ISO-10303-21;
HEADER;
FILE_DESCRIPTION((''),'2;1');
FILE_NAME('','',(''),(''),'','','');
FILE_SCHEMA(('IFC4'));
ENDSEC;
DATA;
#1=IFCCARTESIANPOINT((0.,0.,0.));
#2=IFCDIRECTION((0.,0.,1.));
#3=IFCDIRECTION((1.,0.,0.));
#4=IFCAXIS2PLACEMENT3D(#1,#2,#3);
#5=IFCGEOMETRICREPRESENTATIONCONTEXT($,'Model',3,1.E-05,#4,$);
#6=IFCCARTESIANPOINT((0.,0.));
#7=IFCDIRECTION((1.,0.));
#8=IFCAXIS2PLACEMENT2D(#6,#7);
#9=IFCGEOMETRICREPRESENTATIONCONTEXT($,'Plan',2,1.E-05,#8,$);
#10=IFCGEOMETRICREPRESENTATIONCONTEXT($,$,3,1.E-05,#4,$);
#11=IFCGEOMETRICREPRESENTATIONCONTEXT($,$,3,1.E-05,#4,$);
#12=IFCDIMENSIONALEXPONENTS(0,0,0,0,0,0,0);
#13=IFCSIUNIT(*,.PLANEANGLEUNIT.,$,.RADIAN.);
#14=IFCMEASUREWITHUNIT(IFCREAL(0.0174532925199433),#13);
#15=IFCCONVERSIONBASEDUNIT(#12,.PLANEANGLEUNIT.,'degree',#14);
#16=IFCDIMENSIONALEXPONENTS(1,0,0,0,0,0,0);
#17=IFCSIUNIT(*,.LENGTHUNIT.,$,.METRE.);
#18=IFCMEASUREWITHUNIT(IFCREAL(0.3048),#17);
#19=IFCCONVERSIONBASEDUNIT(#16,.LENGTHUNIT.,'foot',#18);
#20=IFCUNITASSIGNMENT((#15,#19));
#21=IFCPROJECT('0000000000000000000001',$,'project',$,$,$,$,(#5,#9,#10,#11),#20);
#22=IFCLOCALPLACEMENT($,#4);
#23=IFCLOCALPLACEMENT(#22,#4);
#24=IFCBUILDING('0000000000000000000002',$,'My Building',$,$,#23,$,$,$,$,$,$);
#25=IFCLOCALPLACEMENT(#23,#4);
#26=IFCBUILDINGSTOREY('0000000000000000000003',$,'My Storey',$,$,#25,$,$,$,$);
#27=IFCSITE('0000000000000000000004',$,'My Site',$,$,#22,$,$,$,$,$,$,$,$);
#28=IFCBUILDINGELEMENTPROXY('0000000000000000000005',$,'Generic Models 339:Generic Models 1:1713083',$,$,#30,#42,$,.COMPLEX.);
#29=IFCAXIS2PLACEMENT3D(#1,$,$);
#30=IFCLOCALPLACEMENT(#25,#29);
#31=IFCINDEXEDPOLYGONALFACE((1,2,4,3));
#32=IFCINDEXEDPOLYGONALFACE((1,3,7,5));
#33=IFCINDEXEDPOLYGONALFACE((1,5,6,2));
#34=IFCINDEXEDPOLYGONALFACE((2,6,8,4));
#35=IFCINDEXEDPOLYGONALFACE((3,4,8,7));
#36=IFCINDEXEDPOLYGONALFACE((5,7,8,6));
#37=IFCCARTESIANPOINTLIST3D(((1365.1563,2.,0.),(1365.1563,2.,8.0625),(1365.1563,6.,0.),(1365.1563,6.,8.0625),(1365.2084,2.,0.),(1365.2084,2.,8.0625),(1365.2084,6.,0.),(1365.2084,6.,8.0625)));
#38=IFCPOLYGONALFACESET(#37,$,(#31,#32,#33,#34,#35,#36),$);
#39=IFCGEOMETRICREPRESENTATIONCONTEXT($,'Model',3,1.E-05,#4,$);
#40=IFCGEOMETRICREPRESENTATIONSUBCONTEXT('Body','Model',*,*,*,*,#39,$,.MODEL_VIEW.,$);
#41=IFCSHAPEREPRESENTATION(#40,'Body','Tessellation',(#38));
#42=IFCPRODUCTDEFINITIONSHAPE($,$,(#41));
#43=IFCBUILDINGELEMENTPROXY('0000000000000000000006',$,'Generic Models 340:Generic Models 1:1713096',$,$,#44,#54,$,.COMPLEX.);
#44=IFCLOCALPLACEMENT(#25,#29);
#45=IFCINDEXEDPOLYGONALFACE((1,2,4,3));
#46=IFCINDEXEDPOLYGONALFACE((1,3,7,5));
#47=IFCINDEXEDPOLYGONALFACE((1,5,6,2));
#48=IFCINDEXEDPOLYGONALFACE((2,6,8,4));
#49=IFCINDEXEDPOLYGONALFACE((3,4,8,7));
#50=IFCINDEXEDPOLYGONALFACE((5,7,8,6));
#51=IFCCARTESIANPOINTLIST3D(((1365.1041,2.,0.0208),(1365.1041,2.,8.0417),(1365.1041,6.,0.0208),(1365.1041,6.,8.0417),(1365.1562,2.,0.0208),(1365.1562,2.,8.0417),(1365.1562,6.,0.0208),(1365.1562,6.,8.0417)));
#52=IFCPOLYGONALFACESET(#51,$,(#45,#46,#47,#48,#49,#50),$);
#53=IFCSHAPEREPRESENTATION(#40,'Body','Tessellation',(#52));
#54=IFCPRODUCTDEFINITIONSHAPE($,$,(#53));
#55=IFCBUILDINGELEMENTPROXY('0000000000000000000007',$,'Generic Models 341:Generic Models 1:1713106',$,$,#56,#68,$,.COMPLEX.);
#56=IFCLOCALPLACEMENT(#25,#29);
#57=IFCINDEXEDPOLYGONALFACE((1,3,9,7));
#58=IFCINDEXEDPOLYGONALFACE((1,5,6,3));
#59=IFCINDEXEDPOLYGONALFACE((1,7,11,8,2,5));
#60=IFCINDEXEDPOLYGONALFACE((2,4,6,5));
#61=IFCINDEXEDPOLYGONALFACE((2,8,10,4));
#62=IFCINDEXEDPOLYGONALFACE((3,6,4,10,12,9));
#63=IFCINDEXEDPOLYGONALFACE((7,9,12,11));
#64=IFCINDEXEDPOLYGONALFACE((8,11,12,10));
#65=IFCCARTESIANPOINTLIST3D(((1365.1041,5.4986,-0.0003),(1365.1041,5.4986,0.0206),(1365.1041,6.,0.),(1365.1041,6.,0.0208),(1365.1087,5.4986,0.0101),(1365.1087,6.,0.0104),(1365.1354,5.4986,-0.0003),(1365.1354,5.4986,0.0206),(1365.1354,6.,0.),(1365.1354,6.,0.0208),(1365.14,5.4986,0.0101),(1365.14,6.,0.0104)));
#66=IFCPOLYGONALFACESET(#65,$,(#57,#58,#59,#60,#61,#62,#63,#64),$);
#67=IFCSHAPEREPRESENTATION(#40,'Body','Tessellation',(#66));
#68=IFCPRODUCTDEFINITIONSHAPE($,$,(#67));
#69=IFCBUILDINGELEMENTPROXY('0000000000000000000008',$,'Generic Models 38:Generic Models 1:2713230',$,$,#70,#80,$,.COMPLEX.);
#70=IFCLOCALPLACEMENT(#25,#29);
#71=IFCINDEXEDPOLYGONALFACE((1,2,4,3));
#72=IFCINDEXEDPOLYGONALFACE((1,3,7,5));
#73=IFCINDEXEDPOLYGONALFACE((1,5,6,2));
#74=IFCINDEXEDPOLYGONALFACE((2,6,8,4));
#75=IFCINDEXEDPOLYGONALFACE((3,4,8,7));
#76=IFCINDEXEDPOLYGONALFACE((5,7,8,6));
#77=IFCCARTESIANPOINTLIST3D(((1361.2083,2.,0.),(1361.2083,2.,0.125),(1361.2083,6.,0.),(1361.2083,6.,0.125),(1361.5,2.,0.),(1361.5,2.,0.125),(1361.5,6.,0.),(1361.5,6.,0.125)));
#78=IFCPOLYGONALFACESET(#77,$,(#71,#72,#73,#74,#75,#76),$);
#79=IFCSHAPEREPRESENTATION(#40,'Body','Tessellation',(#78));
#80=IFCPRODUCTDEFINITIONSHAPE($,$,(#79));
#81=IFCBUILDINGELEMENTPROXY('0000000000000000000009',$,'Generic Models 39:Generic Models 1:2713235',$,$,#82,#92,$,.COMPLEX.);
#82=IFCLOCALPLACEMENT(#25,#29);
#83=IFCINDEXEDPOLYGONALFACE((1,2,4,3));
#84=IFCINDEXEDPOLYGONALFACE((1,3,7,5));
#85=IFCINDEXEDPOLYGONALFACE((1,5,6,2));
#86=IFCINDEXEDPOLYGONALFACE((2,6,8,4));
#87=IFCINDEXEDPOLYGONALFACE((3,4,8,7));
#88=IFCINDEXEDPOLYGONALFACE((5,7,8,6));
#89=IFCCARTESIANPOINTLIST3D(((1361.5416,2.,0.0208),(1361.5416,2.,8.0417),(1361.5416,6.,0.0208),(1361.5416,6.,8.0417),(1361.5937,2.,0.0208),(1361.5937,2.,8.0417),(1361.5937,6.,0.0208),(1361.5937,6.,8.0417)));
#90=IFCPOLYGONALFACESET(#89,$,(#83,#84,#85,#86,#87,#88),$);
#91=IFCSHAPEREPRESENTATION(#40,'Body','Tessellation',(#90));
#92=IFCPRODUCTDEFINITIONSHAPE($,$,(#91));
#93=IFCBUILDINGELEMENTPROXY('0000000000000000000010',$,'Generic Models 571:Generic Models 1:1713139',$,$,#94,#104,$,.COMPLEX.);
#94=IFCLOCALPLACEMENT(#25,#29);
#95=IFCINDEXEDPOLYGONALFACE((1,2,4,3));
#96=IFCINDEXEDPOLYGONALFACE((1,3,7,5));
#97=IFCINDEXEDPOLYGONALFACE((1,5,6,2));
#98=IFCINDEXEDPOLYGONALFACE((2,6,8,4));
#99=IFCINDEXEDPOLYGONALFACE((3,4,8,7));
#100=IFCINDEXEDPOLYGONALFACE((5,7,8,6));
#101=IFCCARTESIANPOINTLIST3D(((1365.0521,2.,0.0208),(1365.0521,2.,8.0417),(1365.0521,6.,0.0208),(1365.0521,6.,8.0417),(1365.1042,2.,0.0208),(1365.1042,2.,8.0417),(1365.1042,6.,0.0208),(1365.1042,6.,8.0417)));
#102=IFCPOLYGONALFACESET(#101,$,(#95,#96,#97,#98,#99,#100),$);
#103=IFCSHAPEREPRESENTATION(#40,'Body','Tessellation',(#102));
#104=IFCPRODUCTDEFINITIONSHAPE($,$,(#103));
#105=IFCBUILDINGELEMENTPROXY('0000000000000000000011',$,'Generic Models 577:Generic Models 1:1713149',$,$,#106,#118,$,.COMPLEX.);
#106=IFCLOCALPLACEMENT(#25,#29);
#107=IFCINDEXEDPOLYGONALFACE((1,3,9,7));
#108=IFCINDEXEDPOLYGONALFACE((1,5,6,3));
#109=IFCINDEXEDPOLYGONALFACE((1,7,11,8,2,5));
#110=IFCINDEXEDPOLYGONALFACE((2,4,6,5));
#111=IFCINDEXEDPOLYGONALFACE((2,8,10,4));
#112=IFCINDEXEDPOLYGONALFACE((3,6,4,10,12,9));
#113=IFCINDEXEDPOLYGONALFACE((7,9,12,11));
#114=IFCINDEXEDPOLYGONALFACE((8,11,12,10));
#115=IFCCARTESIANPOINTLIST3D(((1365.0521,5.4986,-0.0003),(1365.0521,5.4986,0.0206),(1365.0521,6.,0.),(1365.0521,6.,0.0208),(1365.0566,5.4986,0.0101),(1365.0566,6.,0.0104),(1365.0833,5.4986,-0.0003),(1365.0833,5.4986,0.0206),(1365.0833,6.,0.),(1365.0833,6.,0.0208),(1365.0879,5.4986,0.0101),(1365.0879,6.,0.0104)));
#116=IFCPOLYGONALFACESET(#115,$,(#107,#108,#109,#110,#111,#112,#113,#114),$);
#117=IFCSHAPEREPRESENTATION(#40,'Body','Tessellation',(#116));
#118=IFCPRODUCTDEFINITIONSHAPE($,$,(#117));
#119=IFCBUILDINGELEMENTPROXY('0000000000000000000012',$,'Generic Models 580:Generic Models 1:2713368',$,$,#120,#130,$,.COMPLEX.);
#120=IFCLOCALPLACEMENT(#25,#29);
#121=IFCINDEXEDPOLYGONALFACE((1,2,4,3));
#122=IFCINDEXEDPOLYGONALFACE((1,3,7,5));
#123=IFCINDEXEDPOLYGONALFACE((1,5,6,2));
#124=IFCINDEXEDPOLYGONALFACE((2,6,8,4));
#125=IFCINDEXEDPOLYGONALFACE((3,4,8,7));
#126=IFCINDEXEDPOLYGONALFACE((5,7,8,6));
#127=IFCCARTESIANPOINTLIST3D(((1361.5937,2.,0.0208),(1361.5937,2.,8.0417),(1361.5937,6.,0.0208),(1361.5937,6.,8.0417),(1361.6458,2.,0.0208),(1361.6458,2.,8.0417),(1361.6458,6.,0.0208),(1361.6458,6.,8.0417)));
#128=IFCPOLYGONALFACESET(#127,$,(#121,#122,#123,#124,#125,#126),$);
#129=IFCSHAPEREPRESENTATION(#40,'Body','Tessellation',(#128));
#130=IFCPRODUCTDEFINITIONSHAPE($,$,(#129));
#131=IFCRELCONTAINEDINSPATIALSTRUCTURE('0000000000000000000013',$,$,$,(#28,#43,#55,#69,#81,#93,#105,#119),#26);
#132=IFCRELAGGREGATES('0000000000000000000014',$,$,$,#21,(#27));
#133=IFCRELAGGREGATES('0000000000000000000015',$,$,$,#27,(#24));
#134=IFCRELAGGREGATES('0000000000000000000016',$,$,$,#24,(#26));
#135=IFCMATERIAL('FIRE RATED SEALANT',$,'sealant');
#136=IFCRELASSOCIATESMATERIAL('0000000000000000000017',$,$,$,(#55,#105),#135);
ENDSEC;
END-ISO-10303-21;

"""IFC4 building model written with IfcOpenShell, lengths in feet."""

from ifc_helpers import new_model, entity, si_unit, converted_unit, frame, origin_with_axes, origin_2d_with_axis, place, context, subcontext, project, spatial, polyline, line, indexed_curve, outline, extrude, material, element, save


model = new_model("IFC4")

# Units and contexts
model_context_1 = context("Model", 3, precision=1e-05, world=origin_with_axes())
plan_context = context("Plan", 2, precision=1e-05, world=origin_2d_with_axis())
model_context_2 = context("Model", 3, precision=1e-05, world=origin_with_axes())
context_of_model_1 = context(None, 3, precision=1e-05, world=origin_with_axes())
context_of_model_2 = context(None, 3, precision=1e-05, world=origin_with_axes())
body_context = subcontext(model_context_2, "Body", "Model", "MODEL_VIEW")
ifc_project = project(units=[converted_unit("PLANEANGLEUNIT", "degree", entity("IfcReal", 0.0174532925199433), si_unit("PLANEANGLEUNIT", "RADIAN"), dimensions=[0, 0, 0, 0, 0, 0, 0]), converted_unit("LENGTHUNIT", "foot", entity("IfcReal", 0.3048), si_unit("LENGTHUNIT", "METRE"), dimensions=[1, 0, 0, 0, 0, 0, 0])], contexts=[model_context_1, plan_context, context_of_model_1, context_of_model_2])

# Site, building, storey
site_placement = place(None, origin_with_axes())
site = spatial("IfcSite", under=ifc_project, at=site_placement, Name="My Site")
building_placement = place(site_placement, origin_with_axes())
building = spatial("IfcBuilding", under=site, at=building_placement, Name="My Building")
storey_placement = place(building_placement, origin_with_axes())
storey = spatial("IfcBuildingStorey", under=building, at=storey_placement, Name="My Storey")

# Building element proxies
ifc_material_1 = material(Name="FIRE RATED SEALANT", Category="sealant")
proxy_1_placement = place(storey_placement, frame((1365.1563, 6.0, 0.0), z_axis=(0.0, -1.0, 0.0), x_axis=(0.0, 0.0, 1.0)))
element("IfcBuildingElementProxy", 1, at=proxy_1_placement, inside=storey, Name="Generic Models 339:Generic Models 1:1713083", PredefinedType="COMPLEX", context=body_context, shape_type="SweptSolid", body=[
    extrude(outline(polyline([(-4.0312, -0.026), (4.0312, -0.026), (4.0312, 0.026), (-4.0312, 0.026), (-4.0312, -0.026)])), frame((4.0312, -0.026, 0.0), z_axis=(0.0, 0.0, -1.0), x_axis=(-1.0, 0.0, 0.0)), (0.0, 0.0, -1.0), 4.0),
])
proxy_2_placement = place(storey_placement, frame((1365.1041, 6.0, 0.0208), z_axis=(0.0, -1.0, 0.0), x_axis=(0.0, 0.0, 1.0)))
element("IfcBuildingElementProxy", 2, at=proxy_2_placement, inside=storey, Name="Generic Models 340:Generic Models 1:1713096", PredefinedType="COMPLEX", context=body_context, shape_type="SweptSolid", body=[
    extrude(outline(polyline([(-0.026, -4.0104), (0.026, -4.0104), (0.026, 4.0104), (-0.026, 4.0104), (-0.026, -4.0104)])), frame((4.0104, -0.026, 0.0), z_axis=(0.0, 0.0, -1.0), x_axis=(0.0, 1.0, 0.0)), (0.0, 0.0, -1.0), 4.0),
])
proxy_3_placement = place(storey_placement, frame((1365.1041, 6.0, 0.0), z_axis=(0.0, -1.0, 0.0), x_axis=(0.0, 0.0, 1.0)))
element("IfcBuildingElementProxy", 3, at=proxy_3_placement, inside=storey, material=ifc_material_1, Name="Generic Models 341:Generic Models 1:1713106", PredefinedType="COMPLEX", context=body_context, shape_type="SweptSolid", body=[
    extrude(outline(polyline([(0.0201, 0.0), (-0.0066, 0.0162), (-0.016, 0.0097), (-0.0175, -0.0016), (0.0093, -0.0178), (0.0107, -0.0065), (0.0201, 0.0)])), frame((0.0104, -0.0172, 0.0), z_axis=(0.0, 0.0, -1.0), x_axis=(0.51911, 0.854708, 0.0)), (-0.000285, -0.000479, -1.0), 0.5014),
])
proxy_4_placement = place(storey_placement, frame((1361.2083, 6.0, 0.0), z_axis=(0.0, -1.0, 0.0), x_axis=(0.0, 0.0, 1.0)))
element("IfcBuildingElementProxy", 4, at=proxy_4_placement, inside=storey, Name="Generic Models 38:Generic Models 1:2713230", PredefinedType="COMPLEX", context=body_context, shape_type="SweptSolid", body=[
    extrude(outline(polyline([(-0.0625, -0.1458), (0.0625, -0.1458), (0.0625, 0.1458), (-0.0625, 0.1458), (-0.0625, -0.1458)])), frame((0.0625, -0.1458, 0.0), z_axis=(0.0, 0.0, -1.0), x_axis=(1.0, 0.0, 0.0)), (0.0, 0.0, -1.0), 4.0),
])
proxy_5_placement = place(storey_placement, frame((1361.5416, 6.0, 0.0208), z_axis=(0.0, -1.0, 0.0), x_axis=(0.0, 0.0, 1.0)))
element("IfcBuildingElementProxy", 5, at=proxy_5_placement, inside=storey, Name="Generic Models 39:Generic Models 1:2713235", PredefinedType="COMPLEX", context=body_context, shape_type="SweptSolid", body=[
    extrude(outline(polyline([(-0.026, -4.0104), (0.026, -4.0104), (0.026, 4.0104), (-0.026, 4.0104), (-0.026, -4.0104)])), frame((4.0104, -0.026, 0.0), z_axis=(0.0, 0.0, -1.0), x_axis=(0.0, 1.0, 0.0)), (0.0, 0.0, -1.0), 4.0),
])
proxy_6_placement = place(storey_placement, frame((1365.0521, 6.0, 0.0208), z_axis=(0.0, -1.0, 0.0), x_axis=(0.0, 0.0, 1.0)))
element("IfcBuildingElementProxy", 6, at=proxy_6_placement, inside=storey, Name="Generic Models 571:Generic Models 1:1713139", PredefinedType="COMPLEX", context=body_context, shape_type="SweptSolid", body=[
    extrude(outline(indexed_curve([(-4.0104, -0.026), (4.0104, -0.026), (4.0104, 0.026), (-4.0104, 0.026)], segments=[line(4, 1), line(1, 2), line(2, 3), line(3, 4)], self_intersect=False)), frame((4.0104, -0.026, 0.0), z_axis=(0.0, 0.0, -1.0), x_axis=(1.0, 0.0, 0.0)), (0.0, 0.0, -1.0), 4.0),
])
proxy_7_placement = place(storey_placement, frame((1365.0521, 6.0, 0.0), z_axis=(0.0, -1.0, 0.0), x_axis=(0.0, 0.0, 1.0)))
element("IfcBuildingElementProxy", 7, at=proxy_7_placement, inside=storey, material=ifc_material_1, Name="Generic Models 577:Generic Models 1:1713149", PredefinedType="COMPLEX", context=body_context, shape_type="SweptSolid", body=[
    extrude(outline(polyline([(0.0201, 0.0), (-0.0066, 0.0162), (-0.016, 0.0097), (-0.0175, -0.0016), (0.0093, -0.0178), (0.0107, -0.0065), (0.0201, 0.0)])), frame((0.0104, -0.0172, 0.0), z_axis=(0.0, 0.0, -1.0), x_axis=(0.51911, 0.854708, 0.0)), (-0.000285, -0.000479, -1.0), 0.5014),
])
proxy_8_placement = place(storey_placement, frame((1361.5937, 6.0, 0.0208), z_axis=(0.0, -1.0, 0.0), x_axis=(0.0, 0.0, 1.0)))
element("IfcBuildingElementProxy", 8, at=proxy_8_placement, inside=storey, Name="Generic Models 580:Generic Models 1:2713368", PredefinedType="COMPLEX", context=body_context, shape_type="SweptSolid", body=[
    extrude(outline(polyline([(-4.0104, -0.026), (4.0104, -0.026), (4.0104, 0.026), (-4.0104, 0.026), (-4.0104, -0.026)])), frame((4.0104, -0.026, 0.0), z_axis=(0.0, 0.0, -1.0), x_axis=(1.0, 0.0, 0.0)), (0.0, 0.0, -1.0), 4.0),
])

save(model, "model.ifc")
